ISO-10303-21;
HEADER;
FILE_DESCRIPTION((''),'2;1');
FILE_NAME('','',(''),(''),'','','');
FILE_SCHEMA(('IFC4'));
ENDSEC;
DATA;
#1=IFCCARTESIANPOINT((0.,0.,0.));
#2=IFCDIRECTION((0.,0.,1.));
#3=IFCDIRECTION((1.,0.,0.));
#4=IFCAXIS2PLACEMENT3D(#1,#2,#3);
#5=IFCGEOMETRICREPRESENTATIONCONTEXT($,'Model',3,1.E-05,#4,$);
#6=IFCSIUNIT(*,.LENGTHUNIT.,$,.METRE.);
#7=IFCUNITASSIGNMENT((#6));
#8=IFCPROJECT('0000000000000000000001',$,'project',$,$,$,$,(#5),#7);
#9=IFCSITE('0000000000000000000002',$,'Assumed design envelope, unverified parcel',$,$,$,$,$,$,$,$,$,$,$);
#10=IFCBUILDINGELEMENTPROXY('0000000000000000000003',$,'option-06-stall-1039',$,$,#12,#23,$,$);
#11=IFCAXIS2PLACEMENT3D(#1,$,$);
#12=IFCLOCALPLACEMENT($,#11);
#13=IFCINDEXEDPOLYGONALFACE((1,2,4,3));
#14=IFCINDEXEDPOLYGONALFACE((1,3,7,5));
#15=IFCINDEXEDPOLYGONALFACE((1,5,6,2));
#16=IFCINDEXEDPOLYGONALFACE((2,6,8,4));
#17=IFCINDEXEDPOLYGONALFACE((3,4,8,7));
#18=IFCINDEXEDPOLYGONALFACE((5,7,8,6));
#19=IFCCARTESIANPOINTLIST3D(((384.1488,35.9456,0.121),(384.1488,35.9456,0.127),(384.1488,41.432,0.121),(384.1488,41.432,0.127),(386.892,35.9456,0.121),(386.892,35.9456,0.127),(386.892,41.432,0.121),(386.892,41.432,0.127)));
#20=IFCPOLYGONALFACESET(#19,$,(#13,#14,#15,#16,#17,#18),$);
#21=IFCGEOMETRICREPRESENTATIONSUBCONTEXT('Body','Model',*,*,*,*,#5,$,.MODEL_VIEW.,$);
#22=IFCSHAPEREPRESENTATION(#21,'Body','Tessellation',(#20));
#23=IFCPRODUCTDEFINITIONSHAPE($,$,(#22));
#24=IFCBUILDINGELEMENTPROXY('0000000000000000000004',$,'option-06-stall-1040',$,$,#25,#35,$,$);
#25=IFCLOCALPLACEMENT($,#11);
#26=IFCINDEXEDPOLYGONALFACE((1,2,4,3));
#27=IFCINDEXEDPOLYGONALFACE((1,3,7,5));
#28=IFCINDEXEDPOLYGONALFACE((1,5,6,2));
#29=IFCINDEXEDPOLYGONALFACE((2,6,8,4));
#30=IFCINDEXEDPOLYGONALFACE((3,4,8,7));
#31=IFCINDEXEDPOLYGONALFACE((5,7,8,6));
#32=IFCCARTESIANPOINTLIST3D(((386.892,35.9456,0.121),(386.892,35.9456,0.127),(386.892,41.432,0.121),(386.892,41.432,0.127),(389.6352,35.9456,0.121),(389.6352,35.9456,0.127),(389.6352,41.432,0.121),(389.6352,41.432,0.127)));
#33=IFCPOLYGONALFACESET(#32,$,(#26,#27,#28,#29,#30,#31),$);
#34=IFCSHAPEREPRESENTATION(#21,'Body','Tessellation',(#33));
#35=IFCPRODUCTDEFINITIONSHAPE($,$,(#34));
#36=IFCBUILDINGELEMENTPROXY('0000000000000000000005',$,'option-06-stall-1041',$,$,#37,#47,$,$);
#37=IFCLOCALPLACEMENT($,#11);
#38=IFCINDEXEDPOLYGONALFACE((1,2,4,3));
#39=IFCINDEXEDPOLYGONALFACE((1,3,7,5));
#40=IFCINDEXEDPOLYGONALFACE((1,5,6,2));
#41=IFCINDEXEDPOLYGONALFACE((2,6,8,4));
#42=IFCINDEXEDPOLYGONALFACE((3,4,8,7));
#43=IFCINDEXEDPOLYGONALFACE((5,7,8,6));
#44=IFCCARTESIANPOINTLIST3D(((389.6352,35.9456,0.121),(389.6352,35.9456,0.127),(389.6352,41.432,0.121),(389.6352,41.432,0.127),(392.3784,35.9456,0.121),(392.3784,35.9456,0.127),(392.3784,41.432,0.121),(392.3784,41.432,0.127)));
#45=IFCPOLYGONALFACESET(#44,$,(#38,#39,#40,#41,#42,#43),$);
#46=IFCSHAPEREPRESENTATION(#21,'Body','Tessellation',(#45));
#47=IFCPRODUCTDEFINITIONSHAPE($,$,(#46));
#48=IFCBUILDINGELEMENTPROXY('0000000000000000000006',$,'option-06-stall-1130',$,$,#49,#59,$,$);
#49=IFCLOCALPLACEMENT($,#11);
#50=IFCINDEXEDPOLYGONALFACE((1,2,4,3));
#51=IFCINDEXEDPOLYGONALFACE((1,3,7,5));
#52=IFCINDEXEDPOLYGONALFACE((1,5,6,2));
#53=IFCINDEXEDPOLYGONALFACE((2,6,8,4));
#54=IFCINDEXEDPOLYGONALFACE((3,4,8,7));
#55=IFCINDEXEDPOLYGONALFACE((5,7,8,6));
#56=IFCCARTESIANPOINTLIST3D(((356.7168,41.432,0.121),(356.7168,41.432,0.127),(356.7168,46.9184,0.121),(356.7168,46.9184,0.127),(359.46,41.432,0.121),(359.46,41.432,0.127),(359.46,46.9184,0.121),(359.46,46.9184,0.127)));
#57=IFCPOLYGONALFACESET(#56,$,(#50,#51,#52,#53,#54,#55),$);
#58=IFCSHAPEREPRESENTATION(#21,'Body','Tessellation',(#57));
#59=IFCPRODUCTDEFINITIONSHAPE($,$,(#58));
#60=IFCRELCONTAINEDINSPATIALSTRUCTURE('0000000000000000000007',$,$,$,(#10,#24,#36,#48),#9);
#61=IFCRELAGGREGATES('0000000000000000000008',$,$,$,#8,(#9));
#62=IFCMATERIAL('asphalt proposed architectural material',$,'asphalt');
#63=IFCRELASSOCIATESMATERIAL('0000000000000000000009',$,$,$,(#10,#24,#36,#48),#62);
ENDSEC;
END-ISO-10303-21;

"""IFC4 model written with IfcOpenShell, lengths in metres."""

from ifc_helpers import new_model, si_unit, frame, origin_with_axes, place, context, subcontext, project, spatial, rectangle, extrude, material, element, save


model = new_model("IFC4")

# Units and contexts
model_context = context("Model", 3, precision=1e-05, world=origin_with_axes())
body_context = subcontext(model_context, "Body", "Model", "MODEL_VIEW")
ifc_project = project(units=[si_unit("LENGTHUNIT", "METRE")], contexts=[model_context])

# Site
site = spatial("IfcSite", under=ifc_project, Name="Assumed design envelope, unverified parcel")

# Building element proxies
ifc_material = material(Name="asphalt proposed architectural material", Category="asphalt")
for number, where, z_axis, x_axis, name in (
    (1, (385.5204, 38.6888, 0.121), (0.0, 0.0, 1.0), (1.0, 0.0, 0.0), "option-06-stall-1039"),
    (2, (388.2636, 38.6888, 0.121), (0.0, 0.0, 1.0), (1.0, 0.0, 0.0), "option-06-stall-1040"),
    (3, (391.0068, 38.6888, 0.121), (0.0, 0.0, 1.0), (1.0, 0.0, 0.0), "option-06-stall-1041"),
    (4, (358.0884, 44.1752, 0.121), (0.0, 0.0, 1.0), (1.0, 0.0, 0.0), "option-06-stall-1130"),
):
    element("IfcBuildingElementProxy", number, at=place(None, frame(where, z_axis=z_axis, x_axis=x_axis)), inside=site, material=ifc_material, Name=name, context=body_context, shape_type="SweptSolid", body=[
        extrude(rectangle(XDim=2.7432, YDim=5.4864), origin_with_axes(), (0.0, 0.0, 1.0), 0.006),
    ])

save(model, "model.ifc")
